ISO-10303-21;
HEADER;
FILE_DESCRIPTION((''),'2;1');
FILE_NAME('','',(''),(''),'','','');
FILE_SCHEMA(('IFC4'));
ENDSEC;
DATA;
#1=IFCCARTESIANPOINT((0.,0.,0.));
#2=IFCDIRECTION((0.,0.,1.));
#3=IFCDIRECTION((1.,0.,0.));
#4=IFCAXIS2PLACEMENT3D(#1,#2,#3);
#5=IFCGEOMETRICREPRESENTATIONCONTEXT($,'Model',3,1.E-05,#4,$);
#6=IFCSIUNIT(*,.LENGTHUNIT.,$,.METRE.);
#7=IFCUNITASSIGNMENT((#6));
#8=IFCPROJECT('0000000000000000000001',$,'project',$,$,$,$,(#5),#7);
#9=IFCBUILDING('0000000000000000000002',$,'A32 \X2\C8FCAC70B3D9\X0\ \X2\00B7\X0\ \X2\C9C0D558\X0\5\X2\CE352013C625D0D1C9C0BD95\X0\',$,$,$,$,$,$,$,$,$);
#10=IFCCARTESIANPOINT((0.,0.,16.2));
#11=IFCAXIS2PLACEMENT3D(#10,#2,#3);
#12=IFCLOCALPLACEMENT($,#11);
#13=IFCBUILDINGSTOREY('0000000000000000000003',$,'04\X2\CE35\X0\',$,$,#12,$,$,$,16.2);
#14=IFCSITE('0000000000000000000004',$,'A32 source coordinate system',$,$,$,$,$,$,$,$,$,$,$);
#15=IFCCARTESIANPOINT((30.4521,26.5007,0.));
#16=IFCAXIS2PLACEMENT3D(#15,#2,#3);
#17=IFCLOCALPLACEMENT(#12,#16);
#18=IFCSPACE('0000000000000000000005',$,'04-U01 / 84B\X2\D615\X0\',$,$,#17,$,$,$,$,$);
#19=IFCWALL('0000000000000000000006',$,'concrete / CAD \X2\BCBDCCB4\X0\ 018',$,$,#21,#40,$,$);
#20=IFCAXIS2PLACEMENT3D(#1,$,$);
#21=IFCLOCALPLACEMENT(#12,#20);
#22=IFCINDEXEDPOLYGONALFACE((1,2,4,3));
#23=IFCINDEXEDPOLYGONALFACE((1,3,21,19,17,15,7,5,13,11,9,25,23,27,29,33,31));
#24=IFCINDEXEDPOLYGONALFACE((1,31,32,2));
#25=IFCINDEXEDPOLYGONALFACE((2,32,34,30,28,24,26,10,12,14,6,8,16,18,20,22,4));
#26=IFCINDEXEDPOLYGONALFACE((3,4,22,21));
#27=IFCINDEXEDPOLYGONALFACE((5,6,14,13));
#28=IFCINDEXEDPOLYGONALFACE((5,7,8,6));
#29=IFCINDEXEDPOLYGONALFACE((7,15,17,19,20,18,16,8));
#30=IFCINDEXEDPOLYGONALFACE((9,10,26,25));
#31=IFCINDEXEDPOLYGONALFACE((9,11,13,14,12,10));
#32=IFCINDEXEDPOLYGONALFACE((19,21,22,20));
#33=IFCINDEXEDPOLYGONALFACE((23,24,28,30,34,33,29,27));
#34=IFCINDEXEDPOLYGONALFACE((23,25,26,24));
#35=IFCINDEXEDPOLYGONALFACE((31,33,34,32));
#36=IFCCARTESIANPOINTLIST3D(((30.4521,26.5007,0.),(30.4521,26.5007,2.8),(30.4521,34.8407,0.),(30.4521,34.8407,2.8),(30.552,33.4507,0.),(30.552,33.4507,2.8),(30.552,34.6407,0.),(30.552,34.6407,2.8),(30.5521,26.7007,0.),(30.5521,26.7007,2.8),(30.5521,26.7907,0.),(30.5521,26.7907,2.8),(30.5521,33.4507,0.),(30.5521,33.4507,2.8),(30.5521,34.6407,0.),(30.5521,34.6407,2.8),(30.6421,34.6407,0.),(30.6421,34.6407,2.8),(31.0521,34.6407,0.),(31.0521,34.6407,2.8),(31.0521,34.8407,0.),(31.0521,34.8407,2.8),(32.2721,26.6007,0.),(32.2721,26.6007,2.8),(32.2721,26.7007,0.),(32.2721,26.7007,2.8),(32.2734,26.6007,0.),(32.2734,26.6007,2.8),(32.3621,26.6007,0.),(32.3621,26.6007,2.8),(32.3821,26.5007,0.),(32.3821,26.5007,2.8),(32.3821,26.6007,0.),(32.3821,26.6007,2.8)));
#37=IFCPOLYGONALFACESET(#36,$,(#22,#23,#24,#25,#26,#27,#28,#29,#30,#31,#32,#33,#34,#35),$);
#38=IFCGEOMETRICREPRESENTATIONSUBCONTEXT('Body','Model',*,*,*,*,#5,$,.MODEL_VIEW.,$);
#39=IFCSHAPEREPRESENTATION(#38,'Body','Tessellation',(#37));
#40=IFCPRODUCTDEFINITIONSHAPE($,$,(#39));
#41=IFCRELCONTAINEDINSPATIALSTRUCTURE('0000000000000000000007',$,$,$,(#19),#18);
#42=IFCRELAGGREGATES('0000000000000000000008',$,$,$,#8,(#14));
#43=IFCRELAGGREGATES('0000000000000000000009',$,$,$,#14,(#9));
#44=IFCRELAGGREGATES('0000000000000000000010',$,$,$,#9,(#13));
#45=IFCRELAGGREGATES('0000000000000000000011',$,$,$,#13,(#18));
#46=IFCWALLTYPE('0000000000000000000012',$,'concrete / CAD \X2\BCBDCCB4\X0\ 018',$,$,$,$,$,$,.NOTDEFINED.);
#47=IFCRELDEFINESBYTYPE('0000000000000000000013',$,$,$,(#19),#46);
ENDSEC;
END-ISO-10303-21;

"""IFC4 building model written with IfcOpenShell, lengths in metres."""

from ifc_helpers import new_model, si_unit, frame, origin, origin_with_axes, place, context, subcontext, project, spatial, polyline, outline, extrude, source, transform, mapped, type_object, type_shapes, element, save


model = new_model("IFC4")

# Units and contexts
model_context = context("Model", 3, precision=1e-05, world=origin_with_axes())
body_context = subcontext(model_context, "Body", "Model", "MODEL_VIEW")
ifc_project = project(units=[si_unit("LENGTHUNIT", "METRE")], contexts=[model_context])

# Site, building, storey, space
site = spatial("IfcSite", under=ifc_project, Name="A32 source coordinate system")
building = spatial("IfcBuilding", under=site, Name="A32 주거동 · 지하5층–옥탑지붕")
storey_placement = place(None, frame((0.0, 0.0, 16.2), z_axis=(0.0, 0.0, 1.0), x_axis=(1.0, 0.0, 0.0)))
storey = spatial("IfcBuildingStorey", under=building, at=storey_placement, Name="04층", Elevation=16.2)
space_1_placement = place(storey_placement, frame((30.4521, 26.5007, 0.0), z_axis=(0.0, 0.0, 1.0), x_axis=(1.0, 0.0, 0.0)))
space_1 = spatial("IfcSpace", under=storey, at=space_1_placement, Name="04-U01 / 84B형")

# Wall
wall_type_1 = type_object("IfcWallType", Name="concrete / CAD 벽체 018", PredefinedType="NOTDEFINED")
shared_shape_1 = source(origin(), body_context, "Body", "SweptSolid", [
    extrude(outline(polyline([(0.6, 8.34), (0.6, 8.14), (0.19, 8.14), (0.1, 8.14), (0.0999, 8.14), (0.0999, 6.95), (0.1, 6.95), (0.1, 0.29), (0.1, 0.2), (1.82, 0.2), (1.82, 0.1), (1.8213, 0.1), (1.91, 0.1), (1.93, 0.1), (1.93, 0.0), (0.0, 0.0), (0.0, 8.34), (-0.35, 8.34), (-0.35, 8.34), (0.6, 8.34)])), origin(), (0.0, 0.0, 1.0), 2.8),
])
type_shapes(wall_type_1, [shared_shape_1])
wall_1_placement = place(space_1_placement, origin_with_axes())
element("IfcWall", 1, at=wall_1_placement, inside=space_1, type_object=wall_type_1, Name="concrete / CAD 벽체 018", context=body_context, shape_type="MappedRepresentation", body=[
    mapped(shared_shape_1, transform((0.0, 0.0, 0.0), scale=1.0)),
])

save(model, "model.ifc")
